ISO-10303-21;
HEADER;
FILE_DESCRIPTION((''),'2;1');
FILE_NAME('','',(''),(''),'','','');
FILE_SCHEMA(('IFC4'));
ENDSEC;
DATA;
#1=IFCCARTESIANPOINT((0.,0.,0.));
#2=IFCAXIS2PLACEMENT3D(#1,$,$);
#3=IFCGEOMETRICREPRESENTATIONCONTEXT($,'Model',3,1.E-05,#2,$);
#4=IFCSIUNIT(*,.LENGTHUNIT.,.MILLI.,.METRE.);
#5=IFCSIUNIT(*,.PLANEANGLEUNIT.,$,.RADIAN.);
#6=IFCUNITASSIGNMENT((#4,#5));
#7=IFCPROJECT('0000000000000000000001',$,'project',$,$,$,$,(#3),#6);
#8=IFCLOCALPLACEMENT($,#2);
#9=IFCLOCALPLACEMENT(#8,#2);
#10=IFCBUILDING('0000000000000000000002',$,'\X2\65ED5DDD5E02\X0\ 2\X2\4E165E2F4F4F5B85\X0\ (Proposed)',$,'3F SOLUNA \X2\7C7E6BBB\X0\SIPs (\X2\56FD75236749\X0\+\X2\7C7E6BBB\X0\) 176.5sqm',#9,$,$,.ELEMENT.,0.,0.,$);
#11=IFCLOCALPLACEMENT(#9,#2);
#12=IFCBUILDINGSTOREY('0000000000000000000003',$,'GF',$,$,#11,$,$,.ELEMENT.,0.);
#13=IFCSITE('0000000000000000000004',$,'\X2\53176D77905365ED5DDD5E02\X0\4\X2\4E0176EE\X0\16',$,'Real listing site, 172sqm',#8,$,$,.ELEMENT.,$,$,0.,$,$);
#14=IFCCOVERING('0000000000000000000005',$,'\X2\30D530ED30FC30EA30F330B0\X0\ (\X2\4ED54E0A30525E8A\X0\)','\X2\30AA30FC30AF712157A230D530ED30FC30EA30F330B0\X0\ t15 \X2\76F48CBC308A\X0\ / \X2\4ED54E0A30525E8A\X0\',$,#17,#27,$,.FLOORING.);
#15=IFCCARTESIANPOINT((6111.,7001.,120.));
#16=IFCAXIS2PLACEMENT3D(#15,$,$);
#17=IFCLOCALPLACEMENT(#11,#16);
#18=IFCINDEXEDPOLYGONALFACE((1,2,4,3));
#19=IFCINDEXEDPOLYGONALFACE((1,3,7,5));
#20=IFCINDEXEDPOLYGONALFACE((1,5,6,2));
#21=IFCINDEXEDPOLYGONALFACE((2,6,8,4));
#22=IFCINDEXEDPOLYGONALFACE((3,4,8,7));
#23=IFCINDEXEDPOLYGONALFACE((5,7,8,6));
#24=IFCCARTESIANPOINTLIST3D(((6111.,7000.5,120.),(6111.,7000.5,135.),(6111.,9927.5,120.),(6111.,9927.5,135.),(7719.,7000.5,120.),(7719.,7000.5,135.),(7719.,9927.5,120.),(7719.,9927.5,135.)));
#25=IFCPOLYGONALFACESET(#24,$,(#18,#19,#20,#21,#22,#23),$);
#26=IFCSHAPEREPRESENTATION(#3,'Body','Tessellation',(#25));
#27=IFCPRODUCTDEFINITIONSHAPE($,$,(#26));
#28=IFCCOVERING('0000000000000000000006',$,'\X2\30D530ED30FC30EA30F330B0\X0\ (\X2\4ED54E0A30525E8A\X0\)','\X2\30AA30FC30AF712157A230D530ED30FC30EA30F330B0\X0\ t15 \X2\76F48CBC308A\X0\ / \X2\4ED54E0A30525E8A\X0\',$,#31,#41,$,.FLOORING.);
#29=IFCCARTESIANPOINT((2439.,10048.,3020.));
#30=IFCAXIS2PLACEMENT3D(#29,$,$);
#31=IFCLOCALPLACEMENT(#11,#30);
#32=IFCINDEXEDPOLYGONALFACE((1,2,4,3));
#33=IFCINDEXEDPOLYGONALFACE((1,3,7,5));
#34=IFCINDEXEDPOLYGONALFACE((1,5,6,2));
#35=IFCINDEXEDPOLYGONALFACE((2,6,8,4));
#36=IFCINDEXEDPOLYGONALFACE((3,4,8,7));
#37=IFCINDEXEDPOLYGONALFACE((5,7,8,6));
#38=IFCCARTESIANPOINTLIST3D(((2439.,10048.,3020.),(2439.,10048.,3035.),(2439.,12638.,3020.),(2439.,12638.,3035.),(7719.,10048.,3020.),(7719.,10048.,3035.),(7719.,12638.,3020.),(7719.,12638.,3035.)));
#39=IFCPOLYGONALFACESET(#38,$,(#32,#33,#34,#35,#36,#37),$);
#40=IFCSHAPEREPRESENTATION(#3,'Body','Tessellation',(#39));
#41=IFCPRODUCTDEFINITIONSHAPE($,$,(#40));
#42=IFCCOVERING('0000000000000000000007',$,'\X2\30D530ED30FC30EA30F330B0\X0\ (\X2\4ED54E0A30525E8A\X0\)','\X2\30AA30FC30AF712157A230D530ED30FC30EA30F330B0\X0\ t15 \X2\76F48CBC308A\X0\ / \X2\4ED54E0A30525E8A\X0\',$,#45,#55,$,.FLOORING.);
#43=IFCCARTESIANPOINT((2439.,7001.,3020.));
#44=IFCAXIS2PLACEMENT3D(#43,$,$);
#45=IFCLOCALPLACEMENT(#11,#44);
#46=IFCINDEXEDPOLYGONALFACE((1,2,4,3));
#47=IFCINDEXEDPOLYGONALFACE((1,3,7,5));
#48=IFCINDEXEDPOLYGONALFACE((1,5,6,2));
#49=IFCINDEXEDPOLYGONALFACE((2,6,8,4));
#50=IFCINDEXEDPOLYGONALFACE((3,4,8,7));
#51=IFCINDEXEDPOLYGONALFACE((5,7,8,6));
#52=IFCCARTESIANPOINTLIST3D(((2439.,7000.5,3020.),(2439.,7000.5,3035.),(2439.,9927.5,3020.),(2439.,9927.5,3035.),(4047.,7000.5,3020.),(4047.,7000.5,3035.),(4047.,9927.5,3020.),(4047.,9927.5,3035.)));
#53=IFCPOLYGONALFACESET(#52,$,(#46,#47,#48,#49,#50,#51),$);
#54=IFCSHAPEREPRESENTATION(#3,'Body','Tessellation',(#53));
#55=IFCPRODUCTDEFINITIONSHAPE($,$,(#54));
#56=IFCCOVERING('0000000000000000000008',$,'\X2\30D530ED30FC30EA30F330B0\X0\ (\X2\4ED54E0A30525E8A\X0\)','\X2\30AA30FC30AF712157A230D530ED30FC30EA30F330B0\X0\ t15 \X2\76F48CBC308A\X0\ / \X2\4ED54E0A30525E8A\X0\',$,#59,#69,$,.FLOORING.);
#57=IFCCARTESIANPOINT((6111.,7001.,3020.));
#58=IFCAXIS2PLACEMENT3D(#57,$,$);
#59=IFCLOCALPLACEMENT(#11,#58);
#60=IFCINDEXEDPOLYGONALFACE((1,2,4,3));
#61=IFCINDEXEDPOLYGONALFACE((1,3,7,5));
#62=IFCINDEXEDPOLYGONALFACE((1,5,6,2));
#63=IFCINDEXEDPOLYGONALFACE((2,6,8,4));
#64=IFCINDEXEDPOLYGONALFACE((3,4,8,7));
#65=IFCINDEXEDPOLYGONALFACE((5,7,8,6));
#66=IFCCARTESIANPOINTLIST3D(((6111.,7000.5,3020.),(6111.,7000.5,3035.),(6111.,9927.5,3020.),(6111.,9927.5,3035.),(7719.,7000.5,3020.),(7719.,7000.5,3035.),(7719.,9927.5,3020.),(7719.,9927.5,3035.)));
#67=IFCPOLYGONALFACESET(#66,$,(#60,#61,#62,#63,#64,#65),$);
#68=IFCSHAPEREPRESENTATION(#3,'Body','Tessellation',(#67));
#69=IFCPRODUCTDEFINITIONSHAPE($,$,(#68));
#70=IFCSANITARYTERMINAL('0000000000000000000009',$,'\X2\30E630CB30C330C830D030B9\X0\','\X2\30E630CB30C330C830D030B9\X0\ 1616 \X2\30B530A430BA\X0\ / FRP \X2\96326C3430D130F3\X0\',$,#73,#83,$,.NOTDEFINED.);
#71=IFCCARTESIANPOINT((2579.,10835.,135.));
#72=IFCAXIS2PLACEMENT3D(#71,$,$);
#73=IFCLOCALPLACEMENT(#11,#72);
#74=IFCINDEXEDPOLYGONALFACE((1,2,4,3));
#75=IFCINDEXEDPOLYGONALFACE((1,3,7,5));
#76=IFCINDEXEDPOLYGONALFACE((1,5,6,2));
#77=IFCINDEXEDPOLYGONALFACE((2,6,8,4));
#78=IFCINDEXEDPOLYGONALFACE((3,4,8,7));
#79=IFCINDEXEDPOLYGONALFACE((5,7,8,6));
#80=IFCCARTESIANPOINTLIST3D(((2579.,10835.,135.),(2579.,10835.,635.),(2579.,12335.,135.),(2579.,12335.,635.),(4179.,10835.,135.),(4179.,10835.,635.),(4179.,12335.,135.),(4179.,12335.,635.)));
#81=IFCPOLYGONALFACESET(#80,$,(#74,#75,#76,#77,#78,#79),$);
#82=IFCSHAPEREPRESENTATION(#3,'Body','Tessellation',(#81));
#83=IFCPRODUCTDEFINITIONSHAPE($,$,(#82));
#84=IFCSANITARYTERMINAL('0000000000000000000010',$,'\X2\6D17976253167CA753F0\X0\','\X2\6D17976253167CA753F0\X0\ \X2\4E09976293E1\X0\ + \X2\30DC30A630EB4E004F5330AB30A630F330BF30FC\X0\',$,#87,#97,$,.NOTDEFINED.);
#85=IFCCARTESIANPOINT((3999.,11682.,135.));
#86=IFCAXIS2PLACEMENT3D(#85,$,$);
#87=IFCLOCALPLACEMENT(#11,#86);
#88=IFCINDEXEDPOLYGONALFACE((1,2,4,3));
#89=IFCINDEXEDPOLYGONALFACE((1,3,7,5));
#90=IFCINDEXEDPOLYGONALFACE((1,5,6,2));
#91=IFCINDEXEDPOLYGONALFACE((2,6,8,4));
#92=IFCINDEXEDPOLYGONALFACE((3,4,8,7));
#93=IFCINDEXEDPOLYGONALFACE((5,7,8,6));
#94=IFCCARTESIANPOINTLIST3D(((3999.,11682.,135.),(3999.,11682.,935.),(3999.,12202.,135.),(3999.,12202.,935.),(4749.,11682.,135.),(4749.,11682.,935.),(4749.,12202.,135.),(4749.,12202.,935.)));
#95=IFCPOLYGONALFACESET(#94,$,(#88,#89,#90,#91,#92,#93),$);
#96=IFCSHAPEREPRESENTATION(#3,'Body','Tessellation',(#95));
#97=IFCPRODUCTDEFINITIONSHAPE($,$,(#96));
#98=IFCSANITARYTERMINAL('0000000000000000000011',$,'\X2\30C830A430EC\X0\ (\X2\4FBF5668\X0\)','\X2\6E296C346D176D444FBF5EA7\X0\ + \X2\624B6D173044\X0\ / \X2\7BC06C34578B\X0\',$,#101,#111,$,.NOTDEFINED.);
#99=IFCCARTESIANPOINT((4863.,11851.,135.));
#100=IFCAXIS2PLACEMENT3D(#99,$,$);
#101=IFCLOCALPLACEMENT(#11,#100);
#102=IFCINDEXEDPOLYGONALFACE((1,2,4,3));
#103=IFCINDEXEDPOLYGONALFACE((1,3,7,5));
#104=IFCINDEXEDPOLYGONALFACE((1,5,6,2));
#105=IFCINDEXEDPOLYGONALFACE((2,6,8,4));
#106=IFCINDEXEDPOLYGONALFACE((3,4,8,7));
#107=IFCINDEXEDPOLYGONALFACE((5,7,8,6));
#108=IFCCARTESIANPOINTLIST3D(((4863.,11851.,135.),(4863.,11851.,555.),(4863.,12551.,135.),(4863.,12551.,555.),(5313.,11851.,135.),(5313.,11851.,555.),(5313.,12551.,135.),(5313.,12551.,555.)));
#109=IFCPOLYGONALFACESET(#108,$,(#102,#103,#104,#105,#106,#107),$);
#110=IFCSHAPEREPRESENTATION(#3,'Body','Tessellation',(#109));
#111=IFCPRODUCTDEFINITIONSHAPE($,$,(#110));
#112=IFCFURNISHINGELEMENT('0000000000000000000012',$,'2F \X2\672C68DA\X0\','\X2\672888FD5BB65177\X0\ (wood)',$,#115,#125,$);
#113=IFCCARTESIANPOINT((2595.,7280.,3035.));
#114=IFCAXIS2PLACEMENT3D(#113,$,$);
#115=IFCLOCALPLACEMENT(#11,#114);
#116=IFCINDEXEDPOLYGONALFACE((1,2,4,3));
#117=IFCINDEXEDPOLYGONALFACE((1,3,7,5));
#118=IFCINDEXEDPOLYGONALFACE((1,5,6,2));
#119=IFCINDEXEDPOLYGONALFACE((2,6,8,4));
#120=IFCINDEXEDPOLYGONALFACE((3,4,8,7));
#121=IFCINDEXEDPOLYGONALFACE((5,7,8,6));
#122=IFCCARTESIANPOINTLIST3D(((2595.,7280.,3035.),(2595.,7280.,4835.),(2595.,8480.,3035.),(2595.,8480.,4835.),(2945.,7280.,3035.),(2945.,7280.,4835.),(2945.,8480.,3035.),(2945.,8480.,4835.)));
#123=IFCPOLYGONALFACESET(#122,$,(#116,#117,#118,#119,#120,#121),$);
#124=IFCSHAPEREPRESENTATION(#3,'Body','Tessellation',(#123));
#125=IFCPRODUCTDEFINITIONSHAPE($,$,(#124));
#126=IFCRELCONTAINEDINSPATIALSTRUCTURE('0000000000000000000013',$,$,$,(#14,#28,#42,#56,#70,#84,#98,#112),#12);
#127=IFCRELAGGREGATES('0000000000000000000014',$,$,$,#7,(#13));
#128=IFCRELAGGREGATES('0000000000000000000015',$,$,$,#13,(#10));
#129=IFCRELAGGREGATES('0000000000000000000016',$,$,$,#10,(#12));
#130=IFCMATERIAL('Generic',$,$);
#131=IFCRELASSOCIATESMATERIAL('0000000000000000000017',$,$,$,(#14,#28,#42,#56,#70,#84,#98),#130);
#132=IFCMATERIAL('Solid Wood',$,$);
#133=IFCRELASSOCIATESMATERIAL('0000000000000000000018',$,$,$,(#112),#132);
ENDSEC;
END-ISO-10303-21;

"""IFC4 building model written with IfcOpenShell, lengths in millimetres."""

from ifc_helpers import new_model, si_unit, frame, frame_2d, origin, place, context, project, spatial, rectangle, extrude, material, element, save


model = new_model("IFC4")

# Units and contexts
model_context = context("Model", 3, precision=1e-05, world=origin())
ifc_project = project(units=[si_unit("LENGTHUNIT", "METRE", prefix="MILLI"), si_unit("PLANEANGLEUNIT", "RADIAN")], contexts=[model_context])

# Site, building, storey
site_placement = place(None, origin())
site = spatial("IfcSite", under=ifc_project, at=site_placement, Name="北海道旭川市4丁目16", ObjectType="Real listing site, 172sqm", CompositionType="ELEMENT", RefElevation=0.0)
building_placement = place(site_placement, origin())
building = spatial("IfcBuilding", under=site, at=building_placement, Name="旭川市 2世帯住宅 (Proposed)", ObjectType="3F SOLUNA 籾殻SIPs (国産杉+籾殻) 176.5sqm", CompositionType="ELEMENT", ElevationOfRefHeight=0.0, ElevationOfTerrain=0.0)
storey_placement = place(building_placement, origin())
storey = spatial("IfcBuildingStorey", under=building, at=storey_placement, Name="GF", CompositionType="ELEMENT", Elevation=0.0)

# Shared definitions
ifc_material_1 = material(Name="Solid Wood")

# Coverings
ifc_material_2 = material(Name="Generic")
covering_1_placement = place(storey_placement, frame((6111.0, 7001.0, 120.0)))
element("IfcCovering", 1, at=covering_1_placement, inside=storey, material=ifc_material_2, Name="フローリング (仕上げ床)", Description="オーク無垢フローリング t15 直貼り / 仕上げ床", PredefinedType="FLOORING", context=model_context, shape_type="SweptSolid", body=[
    extrude(rectangle(XDim=1608.0, YDim=2927.0, at=frame_2d((804.0, 1463.0))), frame((6111.0, 7001.0, 120.0)), (0.0, 0.0, 1.0), 15.0),
])
covering_2_placement = place(storey_placement, frame((2439.0, 10048.0, 3020.0)))
element("IfcCovering", 2, at=covering_2_placement, inside=storey, material=ifc_material_2, Name="フローリング (仕上げ床)", Description="オーク無垢フローリング t15 直貼り / 仕上げ床", PredefinedType="FLOORING", context=model_context, shape_type="SweptSolid", body=[
    extrude(rectangle(XDim=5280.0, YDim=2590.0, at=frame_2d((2640.0, 1295.0))), frame((2439.0, 10048.0, 3020.0)), (0.0, 0.0, 1.0), 15.0),
])
covering_3_placement = place(storey_placement, frame((2439.0, 7001.0, 3020.0)))
element("IfcCovering", 3, at=covering_3_placement, inside=storey, material=ifc_material_2, Name="フローリング (仕上げ床)", Description="オーク無垢フローリング t15 直貼り / 仕上げ床", PredefinedType="FLOORING", context=model_context, shape_type="SweptSolid", body=[
    extrude(rectangle(XDim=1608.0, YDim=2927.0, at=frame_2d((804.0, 1463.0))), frame((2439.0, 7001.0, 3020.0)), (0.0, 0.0, 1.0), 15.0),
])
covering_4_placement = place(storey_placement, frame((6111.0, 7001.0, 3020.0)))
element("IfcCovering", 4, at=covering_4_placement, inside=storey, material=ifc_material_2, Name="フローリング (仕上げ床)", Description="オーク無垢フローリング t15 直貼り / 仕上げ床", PredefinedType="FLOORING", context=model_context, shape_type="SweptSolid", body=[
    extrude(rectangle(XDim=1608.0, YDim=2927.0, at=frame_2d((804.0, 1463.0))), frame((6111.0, 7001.0, 3020.0)), (0.0, 0.0, 1.0), 15.0),
])

# Sanitary terminals
sanitary_terminal_1_placement = place(storey_placement, frame((2579.0, 10835.0, 135.0)))
element("IfcSanitaryTerminal", 5, at=sanitary_terminal_1_placement, inside=storey, material=ifc_material_2, Name="ユニットバス", Description="ユニットバス 1616 サイズ / FRP 防水パン", PredefinedType="NOTDEFINED", context=model_context, shape_type="SweptSolid", body=[
    extrude(rectangle(XDim=1600.0, YDim=1500.0, at=frame_2d((800.0, 750.0))), frame((2579.0, 10835.0, 135.0)), (0.0, 0.0, 1.0), 500.0),
])
sanitary_terminal_2_placement = place(storey_placement, frame((3999.0, 11682.0, 135.0)))
element("IfcSanitaryTerminal", 6, at=sanitary_terminal_2_placement, inside=storey, material=ifc_material_2, Name="洗面化粧台", Description="洗面化粧台 三面鏡 + ボウル一体カウンター", PredefinedType="NOTDEFINED", context=model_context, shape_type="SweptSolid", body=[
    extrude(rectangle(XDim=750.0, YDim=520.0, at=frame_2d((375.0, 260.0))), frame((3999.0, 11682.0, 135.0)), (0.0, 0.0, 1.0), 800.0),
])
sanitary_terminal_3_placement = place(storey_placement, frame((4863.0, 11851.0, 135.0)))
element("IfcSanitaryTerminal", 7, at=sanitary_terminal_3_placement, inside=storey, material=ifc_material_2, Name="トイレ (便器)", Description="温水洗浄便座 + 手洗い / 節水型", PredefinedType="NOTDEFINED", context=model_context, shape_type="SweptSolid", body=[
    extrude(rectangle(XDim=450.0, YDim=700.0, at=frame_2d((225.0, 350.0))), frame((4863.0, 11851.0, 135.0)), (0.0, 0.0, 1.0), 420.0),
])

# Furnishing element
furnishing_placement = place(storey_placement, frame((2595.0, 7280.0, 3035.0)))
element("IfcFurnishingElement", 8, at=furnishing_placement, inside=storey, material=ifc_material_1, Name="2F 本棚", Description="木製家具 (wood)", context=model_context, shape_type="SweptSolid", body=[
    extrude(rectangle(XDim=350.0, YDim=1200.0, at=frame_2d((175.0, 600.0))), frame((2595.0, 7280.0, 3035.0)), (0.0, 0.0, 1.0), 1800.0),
])

save(model, "model.ifc")
